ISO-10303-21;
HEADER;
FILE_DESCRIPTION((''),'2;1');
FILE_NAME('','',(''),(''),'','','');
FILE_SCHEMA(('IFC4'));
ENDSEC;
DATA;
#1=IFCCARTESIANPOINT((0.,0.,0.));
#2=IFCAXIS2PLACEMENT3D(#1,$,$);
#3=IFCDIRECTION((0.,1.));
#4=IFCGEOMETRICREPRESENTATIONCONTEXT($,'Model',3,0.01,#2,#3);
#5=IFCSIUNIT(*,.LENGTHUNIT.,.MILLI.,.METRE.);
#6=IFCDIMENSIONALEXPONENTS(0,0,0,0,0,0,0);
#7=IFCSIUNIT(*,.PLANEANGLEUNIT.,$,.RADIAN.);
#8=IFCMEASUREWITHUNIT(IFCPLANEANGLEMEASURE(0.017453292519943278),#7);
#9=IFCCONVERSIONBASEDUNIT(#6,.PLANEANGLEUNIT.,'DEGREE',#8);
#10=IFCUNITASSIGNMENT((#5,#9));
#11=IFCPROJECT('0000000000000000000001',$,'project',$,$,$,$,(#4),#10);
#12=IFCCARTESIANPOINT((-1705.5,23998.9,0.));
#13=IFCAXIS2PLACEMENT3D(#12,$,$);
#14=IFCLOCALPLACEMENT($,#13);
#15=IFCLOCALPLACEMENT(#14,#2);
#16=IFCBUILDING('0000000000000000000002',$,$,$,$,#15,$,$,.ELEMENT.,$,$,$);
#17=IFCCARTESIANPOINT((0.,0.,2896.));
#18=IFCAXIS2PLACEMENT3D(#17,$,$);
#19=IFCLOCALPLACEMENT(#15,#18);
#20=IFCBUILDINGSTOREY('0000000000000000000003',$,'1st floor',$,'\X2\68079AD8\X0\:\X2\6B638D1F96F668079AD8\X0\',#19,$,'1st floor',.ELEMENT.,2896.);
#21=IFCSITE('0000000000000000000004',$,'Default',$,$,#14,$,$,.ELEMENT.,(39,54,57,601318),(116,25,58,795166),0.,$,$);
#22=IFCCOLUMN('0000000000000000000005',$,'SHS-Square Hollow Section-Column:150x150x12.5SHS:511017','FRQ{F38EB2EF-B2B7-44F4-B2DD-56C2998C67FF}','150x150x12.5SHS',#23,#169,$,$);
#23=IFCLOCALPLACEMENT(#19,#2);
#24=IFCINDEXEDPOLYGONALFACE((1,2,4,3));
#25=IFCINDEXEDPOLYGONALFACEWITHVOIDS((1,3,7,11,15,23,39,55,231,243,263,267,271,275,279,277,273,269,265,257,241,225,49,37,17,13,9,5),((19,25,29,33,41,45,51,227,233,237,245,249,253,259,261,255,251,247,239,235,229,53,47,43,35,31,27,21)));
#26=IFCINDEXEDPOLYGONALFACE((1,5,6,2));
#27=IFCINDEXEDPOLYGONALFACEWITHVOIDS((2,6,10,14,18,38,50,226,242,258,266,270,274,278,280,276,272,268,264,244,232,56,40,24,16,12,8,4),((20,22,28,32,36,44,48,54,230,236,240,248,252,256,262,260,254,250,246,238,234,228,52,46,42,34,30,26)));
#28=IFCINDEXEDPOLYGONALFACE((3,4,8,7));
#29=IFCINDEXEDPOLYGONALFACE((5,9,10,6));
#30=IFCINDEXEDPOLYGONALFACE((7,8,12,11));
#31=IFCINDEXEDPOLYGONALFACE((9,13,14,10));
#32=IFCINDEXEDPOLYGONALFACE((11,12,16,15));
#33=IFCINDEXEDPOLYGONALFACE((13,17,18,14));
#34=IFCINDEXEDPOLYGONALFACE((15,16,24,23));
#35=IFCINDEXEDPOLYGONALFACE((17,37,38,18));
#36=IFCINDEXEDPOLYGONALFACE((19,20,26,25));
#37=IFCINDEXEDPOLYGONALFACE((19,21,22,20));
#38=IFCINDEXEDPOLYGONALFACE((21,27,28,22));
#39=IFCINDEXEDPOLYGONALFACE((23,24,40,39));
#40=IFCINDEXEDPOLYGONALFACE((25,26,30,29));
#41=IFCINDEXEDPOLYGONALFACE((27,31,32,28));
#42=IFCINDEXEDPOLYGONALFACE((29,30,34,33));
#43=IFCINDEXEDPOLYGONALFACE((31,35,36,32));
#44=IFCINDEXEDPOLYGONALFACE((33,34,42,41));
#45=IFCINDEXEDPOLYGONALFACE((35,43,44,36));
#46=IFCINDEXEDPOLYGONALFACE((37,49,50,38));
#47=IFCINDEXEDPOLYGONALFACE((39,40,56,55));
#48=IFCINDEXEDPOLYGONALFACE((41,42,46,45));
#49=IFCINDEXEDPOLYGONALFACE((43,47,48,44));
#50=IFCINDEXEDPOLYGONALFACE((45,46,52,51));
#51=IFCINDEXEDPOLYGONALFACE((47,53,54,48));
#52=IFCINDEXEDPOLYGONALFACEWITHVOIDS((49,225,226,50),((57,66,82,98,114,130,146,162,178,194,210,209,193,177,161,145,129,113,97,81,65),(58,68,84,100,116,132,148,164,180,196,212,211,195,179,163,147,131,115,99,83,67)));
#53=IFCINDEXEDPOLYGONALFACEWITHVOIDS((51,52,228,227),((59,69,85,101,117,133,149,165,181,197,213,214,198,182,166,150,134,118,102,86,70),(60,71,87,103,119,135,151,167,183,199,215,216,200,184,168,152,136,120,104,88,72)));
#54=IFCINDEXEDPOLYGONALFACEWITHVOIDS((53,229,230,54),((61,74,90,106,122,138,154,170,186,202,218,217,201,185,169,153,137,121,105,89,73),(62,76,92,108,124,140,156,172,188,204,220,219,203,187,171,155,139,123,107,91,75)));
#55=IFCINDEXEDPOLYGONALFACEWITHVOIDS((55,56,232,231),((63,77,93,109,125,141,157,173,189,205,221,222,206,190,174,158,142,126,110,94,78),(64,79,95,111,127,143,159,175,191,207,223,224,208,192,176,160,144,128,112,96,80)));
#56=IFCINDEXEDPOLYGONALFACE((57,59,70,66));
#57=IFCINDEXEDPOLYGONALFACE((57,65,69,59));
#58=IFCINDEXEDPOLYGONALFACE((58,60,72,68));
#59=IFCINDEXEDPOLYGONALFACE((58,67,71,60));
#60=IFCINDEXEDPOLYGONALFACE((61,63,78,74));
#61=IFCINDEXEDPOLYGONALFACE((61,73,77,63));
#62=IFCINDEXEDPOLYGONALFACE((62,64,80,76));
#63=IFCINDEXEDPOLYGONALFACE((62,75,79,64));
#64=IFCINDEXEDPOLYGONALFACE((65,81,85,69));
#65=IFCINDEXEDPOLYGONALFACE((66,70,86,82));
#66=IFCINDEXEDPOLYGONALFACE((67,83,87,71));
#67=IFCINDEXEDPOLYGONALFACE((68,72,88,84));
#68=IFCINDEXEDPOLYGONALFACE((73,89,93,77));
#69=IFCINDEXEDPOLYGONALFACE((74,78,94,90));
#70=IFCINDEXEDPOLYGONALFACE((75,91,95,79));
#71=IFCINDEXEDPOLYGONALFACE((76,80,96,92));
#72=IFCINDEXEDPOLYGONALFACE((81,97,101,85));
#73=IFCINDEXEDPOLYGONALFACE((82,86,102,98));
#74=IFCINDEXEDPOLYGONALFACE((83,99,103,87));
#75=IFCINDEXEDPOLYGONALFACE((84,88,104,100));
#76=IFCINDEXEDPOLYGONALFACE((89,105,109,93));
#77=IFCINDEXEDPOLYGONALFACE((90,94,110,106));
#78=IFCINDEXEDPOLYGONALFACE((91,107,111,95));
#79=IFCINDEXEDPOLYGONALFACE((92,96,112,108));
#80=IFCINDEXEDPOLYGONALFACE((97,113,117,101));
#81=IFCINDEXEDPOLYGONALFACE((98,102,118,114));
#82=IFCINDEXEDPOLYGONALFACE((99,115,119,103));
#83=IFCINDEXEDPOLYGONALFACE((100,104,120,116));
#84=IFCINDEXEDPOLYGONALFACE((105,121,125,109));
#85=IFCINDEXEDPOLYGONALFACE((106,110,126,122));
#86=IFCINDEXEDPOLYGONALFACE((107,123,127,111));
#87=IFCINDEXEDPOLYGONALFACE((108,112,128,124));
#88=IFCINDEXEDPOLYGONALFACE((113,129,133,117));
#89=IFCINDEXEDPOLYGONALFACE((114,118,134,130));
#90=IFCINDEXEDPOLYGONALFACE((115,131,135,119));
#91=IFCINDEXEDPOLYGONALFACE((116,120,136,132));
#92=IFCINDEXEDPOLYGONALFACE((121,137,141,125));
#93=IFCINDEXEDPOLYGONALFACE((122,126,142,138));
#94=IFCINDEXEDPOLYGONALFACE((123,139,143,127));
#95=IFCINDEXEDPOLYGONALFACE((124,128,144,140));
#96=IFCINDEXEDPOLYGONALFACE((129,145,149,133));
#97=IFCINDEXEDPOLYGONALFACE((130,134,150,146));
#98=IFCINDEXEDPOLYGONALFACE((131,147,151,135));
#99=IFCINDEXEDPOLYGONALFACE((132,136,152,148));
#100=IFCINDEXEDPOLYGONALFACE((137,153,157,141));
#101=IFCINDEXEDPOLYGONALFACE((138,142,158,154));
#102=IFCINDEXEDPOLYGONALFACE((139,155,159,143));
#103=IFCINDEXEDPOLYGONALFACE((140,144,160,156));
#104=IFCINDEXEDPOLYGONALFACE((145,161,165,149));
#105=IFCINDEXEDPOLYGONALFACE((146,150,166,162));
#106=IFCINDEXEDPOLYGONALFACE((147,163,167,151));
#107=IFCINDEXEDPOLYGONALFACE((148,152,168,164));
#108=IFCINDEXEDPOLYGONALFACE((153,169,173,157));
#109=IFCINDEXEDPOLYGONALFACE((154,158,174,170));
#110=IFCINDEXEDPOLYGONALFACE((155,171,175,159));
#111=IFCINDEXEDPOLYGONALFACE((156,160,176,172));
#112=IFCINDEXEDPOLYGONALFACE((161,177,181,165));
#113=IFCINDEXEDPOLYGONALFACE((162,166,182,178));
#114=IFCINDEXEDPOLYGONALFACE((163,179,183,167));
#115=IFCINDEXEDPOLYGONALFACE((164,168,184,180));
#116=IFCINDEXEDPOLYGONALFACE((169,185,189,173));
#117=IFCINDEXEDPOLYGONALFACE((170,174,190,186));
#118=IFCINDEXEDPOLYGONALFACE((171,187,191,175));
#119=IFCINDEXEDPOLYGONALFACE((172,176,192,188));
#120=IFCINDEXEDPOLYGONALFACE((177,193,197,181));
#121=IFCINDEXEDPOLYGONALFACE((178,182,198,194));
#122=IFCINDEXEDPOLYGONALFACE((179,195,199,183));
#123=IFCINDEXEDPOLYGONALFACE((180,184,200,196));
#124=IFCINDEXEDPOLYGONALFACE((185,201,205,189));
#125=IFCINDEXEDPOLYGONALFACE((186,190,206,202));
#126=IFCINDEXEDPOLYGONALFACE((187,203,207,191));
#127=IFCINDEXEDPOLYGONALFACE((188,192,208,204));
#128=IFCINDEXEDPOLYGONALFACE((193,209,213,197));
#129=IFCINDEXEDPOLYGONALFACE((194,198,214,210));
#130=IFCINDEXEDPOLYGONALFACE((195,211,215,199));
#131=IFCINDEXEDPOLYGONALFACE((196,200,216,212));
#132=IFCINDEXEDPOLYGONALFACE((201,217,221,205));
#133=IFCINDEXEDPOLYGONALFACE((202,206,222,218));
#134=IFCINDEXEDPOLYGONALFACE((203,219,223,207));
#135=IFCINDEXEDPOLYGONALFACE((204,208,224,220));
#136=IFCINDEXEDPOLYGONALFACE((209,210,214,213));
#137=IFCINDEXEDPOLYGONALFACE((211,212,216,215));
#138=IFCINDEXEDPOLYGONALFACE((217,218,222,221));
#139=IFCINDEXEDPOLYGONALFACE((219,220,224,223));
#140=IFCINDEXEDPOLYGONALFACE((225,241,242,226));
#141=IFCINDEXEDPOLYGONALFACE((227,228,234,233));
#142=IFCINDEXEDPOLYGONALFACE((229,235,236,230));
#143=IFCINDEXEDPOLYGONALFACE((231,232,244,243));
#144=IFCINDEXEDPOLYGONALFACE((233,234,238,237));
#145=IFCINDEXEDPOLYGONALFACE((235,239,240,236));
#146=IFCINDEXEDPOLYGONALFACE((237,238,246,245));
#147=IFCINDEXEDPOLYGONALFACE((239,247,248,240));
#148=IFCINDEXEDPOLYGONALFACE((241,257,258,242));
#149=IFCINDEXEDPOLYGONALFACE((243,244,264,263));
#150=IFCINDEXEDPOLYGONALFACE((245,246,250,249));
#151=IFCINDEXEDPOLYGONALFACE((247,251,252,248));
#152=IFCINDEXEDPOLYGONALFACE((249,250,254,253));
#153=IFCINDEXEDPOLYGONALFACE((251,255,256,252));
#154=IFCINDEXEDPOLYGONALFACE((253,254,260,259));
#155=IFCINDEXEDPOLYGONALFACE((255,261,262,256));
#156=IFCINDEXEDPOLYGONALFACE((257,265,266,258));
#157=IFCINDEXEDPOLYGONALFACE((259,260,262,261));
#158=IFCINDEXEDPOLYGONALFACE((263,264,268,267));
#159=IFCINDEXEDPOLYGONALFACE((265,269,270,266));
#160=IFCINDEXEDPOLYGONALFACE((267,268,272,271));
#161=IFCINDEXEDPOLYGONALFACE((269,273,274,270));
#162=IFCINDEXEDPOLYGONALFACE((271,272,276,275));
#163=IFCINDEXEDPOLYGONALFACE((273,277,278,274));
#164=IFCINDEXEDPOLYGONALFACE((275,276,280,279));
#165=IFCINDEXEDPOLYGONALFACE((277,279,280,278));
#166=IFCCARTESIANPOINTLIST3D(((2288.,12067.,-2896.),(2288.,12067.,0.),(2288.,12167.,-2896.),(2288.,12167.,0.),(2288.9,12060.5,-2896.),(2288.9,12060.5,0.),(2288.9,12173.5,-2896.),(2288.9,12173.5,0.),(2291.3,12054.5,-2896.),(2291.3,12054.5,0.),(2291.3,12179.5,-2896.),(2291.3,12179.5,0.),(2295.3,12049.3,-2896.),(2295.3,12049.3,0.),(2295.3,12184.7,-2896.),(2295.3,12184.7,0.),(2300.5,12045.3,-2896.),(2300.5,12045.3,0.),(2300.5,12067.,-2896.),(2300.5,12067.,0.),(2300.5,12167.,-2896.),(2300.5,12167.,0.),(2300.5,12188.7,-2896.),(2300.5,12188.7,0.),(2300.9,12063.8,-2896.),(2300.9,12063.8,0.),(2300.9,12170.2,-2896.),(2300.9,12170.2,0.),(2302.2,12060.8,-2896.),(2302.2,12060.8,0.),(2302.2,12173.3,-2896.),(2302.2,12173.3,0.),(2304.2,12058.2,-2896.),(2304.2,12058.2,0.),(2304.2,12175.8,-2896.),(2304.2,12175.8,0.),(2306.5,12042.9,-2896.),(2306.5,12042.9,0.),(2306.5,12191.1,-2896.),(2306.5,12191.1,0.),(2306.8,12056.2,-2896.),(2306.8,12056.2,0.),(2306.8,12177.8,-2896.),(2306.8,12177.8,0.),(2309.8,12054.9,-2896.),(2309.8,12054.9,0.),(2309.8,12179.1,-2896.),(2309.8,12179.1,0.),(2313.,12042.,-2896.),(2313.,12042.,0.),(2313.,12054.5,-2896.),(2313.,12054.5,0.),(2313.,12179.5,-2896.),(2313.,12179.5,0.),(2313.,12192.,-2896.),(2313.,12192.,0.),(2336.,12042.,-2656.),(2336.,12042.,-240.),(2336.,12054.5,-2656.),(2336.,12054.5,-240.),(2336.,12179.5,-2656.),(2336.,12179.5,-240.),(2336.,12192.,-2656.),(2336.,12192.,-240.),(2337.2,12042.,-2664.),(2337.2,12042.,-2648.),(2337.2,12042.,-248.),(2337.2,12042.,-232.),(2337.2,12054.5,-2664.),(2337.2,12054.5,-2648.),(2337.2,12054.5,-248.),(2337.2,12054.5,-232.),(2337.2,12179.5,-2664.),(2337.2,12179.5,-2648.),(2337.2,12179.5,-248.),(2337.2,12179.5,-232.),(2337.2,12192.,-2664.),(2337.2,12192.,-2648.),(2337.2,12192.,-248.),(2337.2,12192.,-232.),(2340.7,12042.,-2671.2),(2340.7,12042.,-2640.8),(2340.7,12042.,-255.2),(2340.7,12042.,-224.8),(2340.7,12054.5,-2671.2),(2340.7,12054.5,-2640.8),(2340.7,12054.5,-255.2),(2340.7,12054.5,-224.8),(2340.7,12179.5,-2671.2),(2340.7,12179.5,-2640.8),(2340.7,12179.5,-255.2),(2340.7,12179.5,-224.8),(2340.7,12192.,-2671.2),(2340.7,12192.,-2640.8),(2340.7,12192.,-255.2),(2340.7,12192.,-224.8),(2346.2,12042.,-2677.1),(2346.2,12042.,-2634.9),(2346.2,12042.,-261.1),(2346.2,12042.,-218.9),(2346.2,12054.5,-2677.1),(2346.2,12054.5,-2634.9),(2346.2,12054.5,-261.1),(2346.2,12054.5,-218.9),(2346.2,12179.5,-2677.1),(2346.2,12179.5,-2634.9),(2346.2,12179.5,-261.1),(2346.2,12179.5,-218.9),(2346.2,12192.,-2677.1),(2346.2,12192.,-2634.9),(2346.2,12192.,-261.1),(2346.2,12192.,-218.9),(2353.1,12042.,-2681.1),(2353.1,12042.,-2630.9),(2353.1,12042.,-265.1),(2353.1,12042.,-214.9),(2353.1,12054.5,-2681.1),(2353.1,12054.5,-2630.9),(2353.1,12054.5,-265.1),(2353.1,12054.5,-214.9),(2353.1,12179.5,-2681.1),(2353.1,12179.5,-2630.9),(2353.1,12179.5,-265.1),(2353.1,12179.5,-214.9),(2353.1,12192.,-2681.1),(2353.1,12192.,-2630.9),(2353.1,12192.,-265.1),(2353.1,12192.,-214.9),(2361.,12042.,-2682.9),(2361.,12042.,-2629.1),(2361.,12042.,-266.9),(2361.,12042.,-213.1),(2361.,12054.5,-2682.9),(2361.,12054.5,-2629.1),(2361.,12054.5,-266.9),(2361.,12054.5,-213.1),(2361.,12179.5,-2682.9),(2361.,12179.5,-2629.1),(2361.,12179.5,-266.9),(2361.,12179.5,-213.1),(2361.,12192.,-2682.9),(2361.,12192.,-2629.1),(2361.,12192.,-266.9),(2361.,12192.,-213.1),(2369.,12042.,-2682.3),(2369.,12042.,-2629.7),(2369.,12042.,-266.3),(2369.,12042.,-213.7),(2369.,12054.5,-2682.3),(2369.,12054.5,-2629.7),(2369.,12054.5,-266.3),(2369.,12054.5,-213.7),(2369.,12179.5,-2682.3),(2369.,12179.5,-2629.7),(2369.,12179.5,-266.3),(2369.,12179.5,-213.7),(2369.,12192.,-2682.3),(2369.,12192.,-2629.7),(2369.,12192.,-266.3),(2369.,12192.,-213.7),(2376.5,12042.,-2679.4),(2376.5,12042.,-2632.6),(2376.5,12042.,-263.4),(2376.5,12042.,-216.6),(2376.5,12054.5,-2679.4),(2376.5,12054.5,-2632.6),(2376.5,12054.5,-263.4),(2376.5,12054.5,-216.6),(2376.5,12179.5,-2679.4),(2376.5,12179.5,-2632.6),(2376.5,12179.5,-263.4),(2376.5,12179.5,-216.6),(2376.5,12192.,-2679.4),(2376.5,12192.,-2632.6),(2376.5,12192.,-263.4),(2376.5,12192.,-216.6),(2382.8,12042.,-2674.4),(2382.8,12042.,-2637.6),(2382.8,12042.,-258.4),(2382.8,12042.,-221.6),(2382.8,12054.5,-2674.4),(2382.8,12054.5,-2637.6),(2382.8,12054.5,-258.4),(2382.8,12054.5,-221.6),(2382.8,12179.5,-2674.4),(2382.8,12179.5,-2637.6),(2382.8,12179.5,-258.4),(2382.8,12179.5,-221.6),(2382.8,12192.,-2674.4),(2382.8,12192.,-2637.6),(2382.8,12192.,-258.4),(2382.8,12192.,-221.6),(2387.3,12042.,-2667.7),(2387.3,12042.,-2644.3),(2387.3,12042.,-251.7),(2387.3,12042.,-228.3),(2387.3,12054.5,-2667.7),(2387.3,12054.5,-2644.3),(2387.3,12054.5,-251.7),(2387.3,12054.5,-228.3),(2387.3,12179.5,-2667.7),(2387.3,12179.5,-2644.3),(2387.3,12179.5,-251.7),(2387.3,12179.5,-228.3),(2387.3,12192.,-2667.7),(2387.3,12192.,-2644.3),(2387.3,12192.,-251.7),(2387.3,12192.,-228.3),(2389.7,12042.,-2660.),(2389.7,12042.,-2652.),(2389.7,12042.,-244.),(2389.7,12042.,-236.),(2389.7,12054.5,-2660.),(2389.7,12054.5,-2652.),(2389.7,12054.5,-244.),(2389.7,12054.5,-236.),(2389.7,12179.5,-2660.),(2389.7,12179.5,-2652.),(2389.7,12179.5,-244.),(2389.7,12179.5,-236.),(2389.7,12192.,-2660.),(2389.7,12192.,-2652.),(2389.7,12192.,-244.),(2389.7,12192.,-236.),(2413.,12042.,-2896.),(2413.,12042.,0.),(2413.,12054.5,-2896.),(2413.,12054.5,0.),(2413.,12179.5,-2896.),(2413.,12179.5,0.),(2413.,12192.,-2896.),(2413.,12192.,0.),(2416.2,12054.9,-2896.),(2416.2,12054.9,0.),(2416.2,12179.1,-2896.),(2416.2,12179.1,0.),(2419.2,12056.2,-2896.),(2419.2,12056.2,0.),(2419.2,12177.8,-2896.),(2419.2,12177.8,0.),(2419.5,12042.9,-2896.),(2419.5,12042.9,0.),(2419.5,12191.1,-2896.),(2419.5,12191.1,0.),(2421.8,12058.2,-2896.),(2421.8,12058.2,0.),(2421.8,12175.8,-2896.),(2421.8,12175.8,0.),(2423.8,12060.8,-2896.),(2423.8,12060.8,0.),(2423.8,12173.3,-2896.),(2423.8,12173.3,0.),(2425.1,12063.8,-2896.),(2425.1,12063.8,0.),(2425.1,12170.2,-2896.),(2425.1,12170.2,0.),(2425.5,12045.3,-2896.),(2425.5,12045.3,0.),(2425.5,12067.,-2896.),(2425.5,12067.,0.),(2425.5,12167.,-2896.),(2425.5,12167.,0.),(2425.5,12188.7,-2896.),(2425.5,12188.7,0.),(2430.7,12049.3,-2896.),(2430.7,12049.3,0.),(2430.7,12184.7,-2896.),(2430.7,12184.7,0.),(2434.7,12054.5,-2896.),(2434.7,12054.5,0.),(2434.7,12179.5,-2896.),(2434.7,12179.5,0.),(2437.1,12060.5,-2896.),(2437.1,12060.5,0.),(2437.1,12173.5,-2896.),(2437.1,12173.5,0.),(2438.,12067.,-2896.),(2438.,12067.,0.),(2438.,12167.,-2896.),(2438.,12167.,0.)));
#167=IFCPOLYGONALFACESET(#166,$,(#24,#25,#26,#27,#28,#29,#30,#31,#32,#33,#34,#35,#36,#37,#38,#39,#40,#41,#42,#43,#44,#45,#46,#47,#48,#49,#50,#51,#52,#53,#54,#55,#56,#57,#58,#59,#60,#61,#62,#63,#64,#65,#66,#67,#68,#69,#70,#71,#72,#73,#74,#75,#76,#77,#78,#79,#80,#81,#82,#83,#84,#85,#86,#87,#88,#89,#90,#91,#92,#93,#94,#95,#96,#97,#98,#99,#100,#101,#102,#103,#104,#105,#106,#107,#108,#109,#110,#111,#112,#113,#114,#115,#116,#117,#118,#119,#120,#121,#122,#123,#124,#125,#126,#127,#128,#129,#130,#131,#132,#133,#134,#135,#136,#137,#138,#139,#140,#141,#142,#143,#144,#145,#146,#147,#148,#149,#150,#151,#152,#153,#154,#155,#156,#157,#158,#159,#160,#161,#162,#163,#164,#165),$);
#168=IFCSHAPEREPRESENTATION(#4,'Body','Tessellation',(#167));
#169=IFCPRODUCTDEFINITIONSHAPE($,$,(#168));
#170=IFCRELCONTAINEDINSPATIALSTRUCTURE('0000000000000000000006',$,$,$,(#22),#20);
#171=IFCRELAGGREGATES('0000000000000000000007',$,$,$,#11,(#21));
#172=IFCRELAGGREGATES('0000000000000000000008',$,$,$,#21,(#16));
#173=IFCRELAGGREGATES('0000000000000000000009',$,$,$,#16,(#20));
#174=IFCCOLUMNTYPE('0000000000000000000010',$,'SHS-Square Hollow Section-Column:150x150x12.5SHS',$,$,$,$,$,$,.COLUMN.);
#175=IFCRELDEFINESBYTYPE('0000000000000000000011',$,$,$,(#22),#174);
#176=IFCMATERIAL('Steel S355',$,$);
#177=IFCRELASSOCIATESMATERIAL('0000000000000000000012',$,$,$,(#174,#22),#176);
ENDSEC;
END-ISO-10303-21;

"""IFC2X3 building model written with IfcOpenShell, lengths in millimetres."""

from ifc_helpers import new_model, entity, si_unit, converted_unit, direction, frame, frame_2d, origin, origin_2d, place, context, project, spatial, circle_curve, hollow_rectangle, outline, extrude, material, type_object, element, save


model = new_model("IFC2X3")

# Units and contexts
model_context = context("Model", 3, precision=0.01, world=origin(), true_north=direction((0.0, 1.0)))
ifc_project = project(units=[si_unit("LENGTHUNIT", "METRE", prefix="MILLI"), converted_unit("PLANEANGLEUNIT", "DEGREE", entity("IfcPlaneAngleMeasure", 0.017453292519943278), si_unit("PLANEANGLEUNIT", "RADIAN"), dimensions=[0, 0, 0, 0, 0, 0, 0])], contexts=[model_context])

# Site, building, storey
site_placement = place(None, frame((-1705.5, 23998.9, 0.0)))
site = spatial("IfcSite", under=ifc_project, at=site_placement, Name="Default", CompositionType="ELEMENT", RefLatitude=(39, 54, 57, 601318), RefLongitude=(116, 25, 58, 795166), RefElevation=0.0)
building_placement = place(site_placement, origin())
building = spatial("IfcBuilding", under=site, at=building_placement, CompositionType="ELEMENT")
storey_placement = place(building_placement, frame((0.0, 0.0, 2896.0)))
storey = spatial("IfcBuildingStorey", under=building, at=storey_placement, Name="1st floor", ObjectType="标高:正负零标高", LongName="1st floor", CompositionType="ELEMENT", Elevation=2896.0)

# Column, openings
ifc_material_1 = material(Name="Steel S355")
column_type_1 = type_object("IfcColumnType", Name="SHS-Square Hollow Section-Column:150x150x12.5SHS", PredefinedType="COLUMN", material=ifc_material_1)
column_1_placement = place(storey_placement, frame((2363.0, 12117.0, 0.0), z_axis=(0.0, 0.0, 1.0), x_axis=(0.0, -1.0, 0.0)))
column_1 = element("IfcColumn", 1, at=column_1_placement, inside=storey, type_object=column_type_1, material=ifc_material_1, Name="SHS-Square Hollow Section-Column:150x150x12.5SHS:511017", Description="FRQ{F38EB2EF-B2B7-44F4-B2DD-56C2998C67FF}", ObjectType="150x150x12.5SHS", context=model_context, shape_type="SweptSolid", body=[
    extrude(hollow_rectangle(XDim=150.0, YDim=150.0, WallThickness=12.5, InnerFilletRadius=12.5, OuterFilletRadius=25.0, at=origin_2d()), origin(), (0.0, 0.0, -1.0), 2896.0),
])
opening_1_placement = place(column_1_placement, frame((175.1, 0.0, 0.0), z_axis=(-1.0, 0.0, 0.0), x_axis=(0.0, -1.0, 0.0)))
element("IfcOpeningElement", 2, at=opening_1_placement, cuts=column_1, ObjectType="Opening", context=model_context, shape_type="SweptSolid", body=[
    extrude(outline(circle_curve(frame_2d((0.0, -240.0), x_axis=(1.0, 0.0)), 27.0)), origin(), (0.0, 0.0, 1.0), 350.2),
])
opening_2_placement = place(column_1_placement, frame((175.1, 0.0, -2896.0), z_axis=(-1.0, 0.0, 0.0), x_axis=(0.0, -1.0, 0.0)))
element("IfcOpeningElement", 3, at=opening_2_placement, cuts=column_1, ObjectType="Opening", context=model_context, shape_type="SweptSolid", body=[
    extrude(outline(circle_curve(frame_2d((0.0, 240.0), x_axis=(1.0, 0.0)), 27.0)), origin(), (0.0, 0.0, 1.0), 350.2),
])

save(model, "model.ifc")
